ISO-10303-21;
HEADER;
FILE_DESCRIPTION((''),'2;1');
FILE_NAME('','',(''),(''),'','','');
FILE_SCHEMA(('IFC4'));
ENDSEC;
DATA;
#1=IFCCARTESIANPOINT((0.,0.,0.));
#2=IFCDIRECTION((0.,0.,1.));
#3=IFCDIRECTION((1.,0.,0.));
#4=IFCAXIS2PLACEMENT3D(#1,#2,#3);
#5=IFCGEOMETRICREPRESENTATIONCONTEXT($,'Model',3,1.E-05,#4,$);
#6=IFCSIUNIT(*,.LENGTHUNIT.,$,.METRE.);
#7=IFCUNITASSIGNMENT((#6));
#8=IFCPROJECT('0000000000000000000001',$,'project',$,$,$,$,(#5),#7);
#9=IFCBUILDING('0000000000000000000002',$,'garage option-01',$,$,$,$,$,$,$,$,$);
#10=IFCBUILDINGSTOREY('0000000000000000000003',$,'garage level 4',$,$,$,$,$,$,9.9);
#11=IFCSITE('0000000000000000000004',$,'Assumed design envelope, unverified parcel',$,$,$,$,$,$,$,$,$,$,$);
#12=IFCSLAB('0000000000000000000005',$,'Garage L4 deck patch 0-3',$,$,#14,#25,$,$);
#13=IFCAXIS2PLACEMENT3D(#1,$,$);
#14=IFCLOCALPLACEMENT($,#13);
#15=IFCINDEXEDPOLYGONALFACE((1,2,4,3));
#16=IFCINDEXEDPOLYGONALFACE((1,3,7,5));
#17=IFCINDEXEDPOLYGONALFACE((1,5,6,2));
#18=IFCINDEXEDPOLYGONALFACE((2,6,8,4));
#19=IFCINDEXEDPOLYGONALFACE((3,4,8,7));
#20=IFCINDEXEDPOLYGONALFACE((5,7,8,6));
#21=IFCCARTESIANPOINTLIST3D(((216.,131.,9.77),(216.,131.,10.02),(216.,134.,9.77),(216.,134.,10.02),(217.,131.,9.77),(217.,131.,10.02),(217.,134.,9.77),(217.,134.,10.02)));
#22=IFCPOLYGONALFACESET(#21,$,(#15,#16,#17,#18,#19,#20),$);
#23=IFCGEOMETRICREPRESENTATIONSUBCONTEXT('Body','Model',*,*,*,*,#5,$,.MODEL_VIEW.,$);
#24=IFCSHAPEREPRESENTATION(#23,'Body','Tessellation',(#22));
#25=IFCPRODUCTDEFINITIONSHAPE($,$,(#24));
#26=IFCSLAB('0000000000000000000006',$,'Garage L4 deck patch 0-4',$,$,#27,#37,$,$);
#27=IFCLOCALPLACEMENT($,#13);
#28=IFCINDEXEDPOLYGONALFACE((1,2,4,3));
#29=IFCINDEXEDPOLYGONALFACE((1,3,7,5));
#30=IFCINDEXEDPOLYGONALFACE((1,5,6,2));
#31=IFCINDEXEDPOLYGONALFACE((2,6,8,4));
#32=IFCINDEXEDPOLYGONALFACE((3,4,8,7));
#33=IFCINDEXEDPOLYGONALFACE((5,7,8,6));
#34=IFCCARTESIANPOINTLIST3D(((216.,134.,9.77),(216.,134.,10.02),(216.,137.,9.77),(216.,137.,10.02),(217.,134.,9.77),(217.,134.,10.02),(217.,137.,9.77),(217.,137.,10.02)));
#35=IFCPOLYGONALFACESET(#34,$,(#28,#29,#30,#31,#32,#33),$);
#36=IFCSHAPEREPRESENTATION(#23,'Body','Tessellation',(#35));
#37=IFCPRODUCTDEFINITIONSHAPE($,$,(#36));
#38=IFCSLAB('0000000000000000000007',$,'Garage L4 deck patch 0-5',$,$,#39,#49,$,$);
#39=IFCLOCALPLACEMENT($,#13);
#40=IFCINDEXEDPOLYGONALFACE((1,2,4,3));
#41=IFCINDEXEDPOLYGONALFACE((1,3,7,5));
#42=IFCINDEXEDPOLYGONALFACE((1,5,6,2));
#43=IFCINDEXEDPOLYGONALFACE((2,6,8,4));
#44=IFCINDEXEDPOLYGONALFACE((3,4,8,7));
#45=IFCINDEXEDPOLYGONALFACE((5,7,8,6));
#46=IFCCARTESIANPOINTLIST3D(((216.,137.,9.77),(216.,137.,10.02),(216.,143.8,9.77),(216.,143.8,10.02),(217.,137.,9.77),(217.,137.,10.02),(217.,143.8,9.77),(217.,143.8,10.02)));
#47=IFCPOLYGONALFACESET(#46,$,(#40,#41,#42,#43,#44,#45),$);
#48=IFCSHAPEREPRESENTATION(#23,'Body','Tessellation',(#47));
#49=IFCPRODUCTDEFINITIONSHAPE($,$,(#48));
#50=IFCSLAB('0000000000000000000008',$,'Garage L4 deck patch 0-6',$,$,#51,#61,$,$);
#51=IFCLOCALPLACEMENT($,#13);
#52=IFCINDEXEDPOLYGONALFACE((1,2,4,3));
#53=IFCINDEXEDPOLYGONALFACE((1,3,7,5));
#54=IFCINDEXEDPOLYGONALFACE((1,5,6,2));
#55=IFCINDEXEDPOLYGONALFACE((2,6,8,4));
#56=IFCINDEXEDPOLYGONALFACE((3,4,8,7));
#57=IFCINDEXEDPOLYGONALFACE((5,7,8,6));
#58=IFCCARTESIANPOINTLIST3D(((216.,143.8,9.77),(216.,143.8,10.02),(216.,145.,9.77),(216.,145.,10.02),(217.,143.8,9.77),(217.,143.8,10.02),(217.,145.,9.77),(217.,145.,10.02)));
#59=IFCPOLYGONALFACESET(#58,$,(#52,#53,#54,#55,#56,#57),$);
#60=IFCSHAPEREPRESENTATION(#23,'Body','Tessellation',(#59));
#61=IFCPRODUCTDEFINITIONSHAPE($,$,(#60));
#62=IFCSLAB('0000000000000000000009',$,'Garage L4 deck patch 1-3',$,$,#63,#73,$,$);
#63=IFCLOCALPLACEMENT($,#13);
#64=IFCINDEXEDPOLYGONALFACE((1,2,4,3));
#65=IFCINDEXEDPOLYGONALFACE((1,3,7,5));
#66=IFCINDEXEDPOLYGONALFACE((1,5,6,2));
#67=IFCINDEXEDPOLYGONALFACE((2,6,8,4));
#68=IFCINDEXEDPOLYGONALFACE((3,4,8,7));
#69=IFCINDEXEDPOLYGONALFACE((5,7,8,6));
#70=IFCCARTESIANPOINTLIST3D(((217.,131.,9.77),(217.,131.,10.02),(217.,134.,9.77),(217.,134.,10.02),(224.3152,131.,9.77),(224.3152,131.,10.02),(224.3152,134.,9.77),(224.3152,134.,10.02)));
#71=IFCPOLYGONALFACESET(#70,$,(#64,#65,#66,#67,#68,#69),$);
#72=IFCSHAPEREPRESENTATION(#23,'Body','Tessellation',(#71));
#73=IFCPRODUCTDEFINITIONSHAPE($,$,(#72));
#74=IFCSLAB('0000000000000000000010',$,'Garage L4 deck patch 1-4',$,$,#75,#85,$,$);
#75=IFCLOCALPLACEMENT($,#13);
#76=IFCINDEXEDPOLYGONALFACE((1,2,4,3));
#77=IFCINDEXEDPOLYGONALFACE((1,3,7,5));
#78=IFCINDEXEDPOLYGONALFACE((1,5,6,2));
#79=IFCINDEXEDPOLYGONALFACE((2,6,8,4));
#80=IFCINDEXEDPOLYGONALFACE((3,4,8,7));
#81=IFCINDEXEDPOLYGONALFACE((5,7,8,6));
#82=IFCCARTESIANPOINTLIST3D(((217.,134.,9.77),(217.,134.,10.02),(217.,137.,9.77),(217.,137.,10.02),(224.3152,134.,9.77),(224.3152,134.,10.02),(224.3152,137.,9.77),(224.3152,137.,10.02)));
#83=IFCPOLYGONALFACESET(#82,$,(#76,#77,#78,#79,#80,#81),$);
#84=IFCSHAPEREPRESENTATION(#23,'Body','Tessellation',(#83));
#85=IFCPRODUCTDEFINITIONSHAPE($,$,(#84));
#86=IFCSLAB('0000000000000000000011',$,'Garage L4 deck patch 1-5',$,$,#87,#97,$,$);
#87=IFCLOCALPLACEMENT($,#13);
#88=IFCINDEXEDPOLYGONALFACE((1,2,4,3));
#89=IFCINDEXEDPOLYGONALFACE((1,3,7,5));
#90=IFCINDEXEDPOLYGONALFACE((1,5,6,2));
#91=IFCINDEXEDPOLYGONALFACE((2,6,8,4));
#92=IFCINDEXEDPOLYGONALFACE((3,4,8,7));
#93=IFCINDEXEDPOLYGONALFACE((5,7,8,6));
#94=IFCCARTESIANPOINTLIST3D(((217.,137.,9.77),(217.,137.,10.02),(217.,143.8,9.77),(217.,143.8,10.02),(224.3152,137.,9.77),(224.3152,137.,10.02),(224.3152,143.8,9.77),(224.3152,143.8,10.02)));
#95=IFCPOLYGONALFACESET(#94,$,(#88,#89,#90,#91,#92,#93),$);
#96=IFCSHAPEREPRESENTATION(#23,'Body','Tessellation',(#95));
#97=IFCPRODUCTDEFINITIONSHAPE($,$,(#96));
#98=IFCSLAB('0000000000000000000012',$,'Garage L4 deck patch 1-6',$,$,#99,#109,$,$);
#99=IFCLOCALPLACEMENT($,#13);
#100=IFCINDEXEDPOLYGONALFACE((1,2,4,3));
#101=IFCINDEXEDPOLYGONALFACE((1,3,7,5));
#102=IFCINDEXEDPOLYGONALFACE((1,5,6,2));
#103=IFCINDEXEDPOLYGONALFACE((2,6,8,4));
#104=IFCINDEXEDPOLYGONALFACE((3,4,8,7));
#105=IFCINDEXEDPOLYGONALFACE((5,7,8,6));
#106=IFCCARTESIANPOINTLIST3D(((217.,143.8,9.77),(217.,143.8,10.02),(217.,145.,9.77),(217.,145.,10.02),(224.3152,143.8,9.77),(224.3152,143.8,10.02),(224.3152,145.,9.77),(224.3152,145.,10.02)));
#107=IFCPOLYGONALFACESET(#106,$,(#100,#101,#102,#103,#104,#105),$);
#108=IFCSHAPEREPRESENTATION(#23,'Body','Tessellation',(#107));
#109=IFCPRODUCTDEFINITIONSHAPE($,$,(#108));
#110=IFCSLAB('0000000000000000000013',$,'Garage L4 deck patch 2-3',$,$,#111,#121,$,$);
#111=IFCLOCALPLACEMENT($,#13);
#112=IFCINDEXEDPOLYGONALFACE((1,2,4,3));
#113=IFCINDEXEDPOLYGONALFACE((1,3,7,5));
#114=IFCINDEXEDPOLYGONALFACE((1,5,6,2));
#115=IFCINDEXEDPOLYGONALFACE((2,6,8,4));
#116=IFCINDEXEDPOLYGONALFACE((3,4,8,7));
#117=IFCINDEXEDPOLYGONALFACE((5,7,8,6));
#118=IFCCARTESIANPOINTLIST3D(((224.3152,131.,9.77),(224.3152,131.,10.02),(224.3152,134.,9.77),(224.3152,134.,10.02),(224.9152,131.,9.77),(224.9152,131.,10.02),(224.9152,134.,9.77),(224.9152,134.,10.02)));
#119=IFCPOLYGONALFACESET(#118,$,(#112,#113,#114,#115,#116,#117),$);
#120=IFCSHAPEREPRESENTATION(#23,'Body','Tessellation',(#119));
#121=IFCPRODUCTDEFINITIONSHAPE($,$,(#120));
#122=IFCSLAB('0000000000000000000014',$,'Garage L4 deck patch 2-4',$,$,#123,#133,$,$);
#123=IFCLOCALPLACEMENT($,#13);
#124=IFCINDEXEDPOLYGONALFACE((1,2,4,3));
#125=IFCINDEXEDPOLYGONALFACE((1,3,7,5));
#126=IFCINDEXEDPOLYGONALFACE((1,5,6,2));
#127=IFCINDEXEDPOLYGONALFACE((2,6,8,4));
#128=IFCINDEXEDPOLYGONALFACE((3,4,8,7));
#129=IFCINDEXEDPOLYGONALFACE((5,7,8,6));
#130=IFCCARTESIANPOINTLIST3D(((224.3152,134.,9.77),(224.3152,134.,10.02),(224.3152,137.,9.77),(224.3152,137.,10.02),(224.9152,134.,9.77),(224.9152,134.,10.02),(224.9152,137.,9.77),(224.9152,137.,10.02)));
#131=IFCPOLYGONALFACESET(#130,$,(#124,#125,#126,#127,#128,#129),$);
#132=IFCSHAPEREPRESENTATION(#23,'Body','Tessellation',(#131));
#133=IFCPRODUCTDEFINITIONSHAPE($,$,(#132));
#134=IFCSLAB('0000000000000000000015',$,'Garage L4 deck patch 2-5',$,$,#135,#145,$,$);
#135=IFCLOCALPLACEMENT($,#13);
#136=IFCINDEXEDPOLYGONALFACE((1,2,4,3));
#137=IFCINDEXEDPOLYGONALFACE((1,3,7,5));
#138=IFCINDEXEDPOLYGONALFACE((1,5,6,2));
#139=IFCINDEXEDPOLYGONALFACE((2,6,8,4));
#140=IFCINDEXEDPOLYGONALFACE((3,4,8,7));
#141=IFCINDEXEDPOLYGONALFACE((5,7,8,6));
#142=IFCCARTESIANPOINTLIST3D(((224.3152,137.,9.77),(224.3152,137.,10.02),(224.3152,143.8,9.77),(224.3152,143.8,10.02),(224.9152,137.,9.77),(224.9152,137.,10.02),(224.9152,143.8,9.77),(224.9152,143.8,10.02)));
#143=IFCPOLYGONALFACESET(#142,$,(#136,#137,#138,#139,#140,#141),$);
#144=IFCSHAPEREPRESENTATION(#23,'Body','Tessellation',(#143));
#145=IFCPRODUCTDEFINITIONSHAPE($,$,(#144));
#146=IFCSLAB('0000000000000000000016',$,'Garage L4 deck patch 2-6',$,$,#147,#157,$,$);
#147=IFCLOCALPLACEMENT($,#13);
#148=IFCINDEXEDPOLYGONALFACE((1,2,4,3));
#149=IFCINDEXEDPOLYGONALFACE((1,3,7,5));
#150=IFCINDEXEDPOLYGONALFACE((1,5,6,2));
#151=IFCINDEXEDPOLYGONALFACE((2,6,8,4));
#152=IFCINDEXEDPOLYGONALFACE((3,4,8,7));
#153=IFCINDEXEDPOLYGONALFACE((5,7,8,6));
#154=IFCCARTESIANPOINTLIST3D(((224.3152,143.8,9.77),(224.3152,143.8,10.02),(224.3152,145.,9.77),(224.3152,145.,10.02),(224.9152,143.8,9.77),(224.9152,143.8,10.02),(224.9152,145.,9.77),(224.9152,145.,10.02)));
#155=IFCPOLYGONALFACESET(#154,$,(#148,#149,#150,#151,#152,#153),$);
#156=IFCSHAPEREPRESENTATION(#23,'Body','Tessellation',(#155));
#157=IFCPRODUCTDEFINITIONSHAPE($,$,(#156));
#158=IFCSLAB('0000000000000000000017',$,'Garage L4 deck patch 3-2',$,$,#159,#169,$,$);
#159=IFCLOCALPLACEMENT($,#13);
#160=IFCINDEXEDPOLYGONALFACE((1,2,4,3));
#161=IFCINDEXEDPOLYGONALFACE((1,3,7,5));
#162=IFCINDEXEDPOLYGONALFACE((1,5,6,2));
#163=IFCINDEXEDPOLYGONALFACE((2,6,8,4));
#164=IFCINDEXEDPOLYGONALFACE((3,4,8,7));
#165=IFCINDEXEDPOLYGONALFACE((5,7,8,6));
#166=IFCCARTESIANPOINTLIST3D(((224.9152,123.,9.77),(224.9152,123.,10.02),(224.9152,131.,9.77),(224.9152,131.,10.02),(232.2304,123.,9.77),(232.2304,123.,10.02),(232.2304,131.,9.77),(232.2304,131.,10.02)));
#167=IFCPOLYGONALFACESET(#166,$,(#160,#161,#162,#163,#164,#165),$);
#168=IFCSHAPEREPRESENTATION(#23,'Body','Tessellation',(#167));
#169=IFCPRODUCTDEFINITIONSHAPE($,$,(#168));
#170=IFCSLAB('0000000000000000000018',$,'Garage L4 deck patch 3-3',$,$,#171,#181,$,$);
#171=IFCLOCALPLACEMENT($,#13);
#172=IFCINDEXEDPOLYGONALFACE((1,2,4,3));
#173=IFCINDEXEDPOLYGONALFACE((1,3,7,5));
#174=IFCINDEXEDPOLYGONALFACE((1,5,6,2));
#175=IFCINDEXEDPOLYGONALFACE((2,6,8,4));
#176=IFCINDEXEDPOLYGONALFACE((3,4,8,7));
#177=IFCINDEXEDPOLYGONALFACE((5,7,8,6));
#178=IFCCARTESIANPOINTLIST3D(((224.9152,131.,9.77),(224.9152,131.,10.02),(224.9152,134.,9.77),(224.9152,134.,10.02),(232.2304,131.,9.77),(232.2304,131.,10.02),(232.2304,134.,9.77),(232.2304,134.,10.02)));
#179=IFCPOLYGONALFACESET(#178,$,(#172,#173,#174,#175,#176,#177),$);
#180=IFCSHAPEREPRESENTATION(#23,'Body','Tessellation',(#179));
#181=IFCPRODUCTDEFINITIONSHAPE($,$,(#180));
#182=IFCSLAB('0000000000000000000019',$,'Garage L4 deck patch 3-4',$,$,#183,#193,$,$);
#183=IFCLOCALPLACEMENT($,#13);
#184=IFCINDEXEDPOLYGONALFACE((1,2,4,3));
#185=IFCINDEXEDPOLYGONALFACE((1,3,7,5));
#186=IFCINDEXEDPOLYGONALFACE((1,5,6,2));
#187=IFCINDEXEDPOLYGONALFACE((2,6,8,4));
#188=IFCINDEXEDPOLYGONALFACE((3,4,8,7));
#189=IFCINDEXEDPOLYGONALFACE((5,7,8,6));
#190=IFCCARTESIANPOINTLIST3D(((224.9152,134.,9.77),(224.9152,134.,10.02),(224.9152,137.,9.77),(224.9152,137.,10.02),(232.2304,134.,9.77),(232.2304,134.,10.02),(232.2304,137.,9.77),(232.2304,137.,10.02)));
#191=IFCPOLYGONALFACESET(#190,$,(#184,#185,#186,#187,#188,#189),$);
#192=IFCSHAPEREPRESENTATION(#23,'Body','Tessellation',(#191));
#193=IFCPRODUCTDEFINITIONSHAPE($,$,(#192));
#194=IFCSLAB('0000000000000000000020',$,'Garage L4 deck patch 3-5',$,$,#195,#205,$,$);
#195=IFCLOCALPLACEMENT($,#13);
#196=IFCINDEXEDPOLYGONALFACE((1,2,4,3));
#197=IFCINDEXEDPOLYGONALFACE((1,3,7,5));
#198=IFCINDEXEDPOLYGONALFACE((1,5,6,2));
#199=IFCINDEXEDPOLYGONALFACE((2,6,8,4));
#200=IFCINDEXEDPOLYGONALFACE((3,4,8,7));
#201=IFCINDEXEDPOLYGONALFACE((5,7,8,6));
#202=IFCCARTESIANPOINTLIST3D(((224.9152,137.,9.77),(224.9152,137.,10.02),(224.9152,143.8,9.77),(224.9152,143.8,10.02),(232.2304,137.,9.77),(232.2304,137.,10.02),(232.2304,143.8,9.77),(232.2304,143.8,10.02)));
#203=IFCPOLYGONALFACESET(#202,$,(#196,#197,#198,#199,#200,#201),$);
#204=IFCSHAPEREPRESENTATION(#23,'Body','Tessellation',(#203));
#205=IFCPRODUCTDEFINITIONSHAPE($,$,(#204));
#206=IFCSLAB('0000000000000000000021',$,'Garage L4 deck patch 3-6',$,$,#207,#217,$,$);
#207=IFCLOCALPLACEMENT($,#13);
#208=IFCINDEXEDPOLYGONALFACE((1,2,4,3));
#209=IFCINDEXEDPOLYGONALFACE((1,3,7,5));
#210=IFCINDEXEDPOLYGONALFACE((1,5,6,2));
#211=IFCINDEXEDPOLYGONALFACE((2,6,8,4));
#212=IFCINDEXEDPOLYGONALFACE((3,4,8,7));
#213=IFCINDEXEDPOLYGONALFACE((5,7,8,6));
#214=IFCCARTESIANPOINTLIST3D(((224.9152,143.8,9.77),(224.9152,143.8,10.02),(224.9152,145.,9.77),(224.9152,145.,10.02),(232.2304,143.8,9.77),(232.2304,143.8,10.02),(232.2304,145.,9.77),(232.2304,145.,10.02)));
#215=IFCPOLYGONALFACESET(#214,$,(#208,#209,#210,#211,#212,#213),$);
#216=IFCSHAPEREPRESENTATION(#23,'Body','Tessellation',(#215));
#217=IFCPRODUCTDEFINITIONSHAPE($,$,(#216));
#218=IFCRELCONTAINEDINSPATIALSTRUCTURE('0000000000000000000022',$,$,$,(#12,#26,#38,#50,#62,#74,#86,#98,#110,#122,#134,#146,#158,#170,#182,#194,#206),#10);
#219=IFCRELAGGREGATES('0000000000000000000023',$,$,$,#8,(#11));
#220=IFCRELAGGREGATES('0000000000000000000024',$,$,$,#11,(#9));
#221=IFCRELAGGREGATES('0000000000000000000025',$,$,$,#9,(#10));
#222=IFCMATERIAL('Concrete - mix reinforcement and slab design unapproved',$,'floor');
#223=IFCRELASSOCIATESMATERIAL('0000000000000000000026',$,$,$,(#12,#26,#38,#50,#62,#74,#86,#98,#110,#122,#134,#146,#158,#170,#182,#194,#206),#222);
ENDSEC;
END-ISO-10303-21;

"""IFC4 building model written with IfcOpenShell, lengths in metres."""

from ifc_helpers import new_model, si_unit, frame, origin_with_axes, place, context, subcontext, project, spatial, rectangle, extrude, material, element, save


model = new_model("IFC4")

# Units and contexts
model_context = context("Model", 3, precision=1e-05, world=origin_with_axes())
body_context = subcontext(model_context, "Body", "Model", "MODEL_VIEW")
ifc_project = project(units=[si_unit("LENGTHUNIT", "METRE")], contexts=[model_context])

# Site, building, storey
site = spatial("IfcSite", under=ifc_project, Name="Assumed design envelope, unverified parcel")
building = spatial("IfcBuilding", under=site, Name="garage option-01")
storey = spatial("IfcBuildingStorey", under=building, Name="garage level 4", Elevation=9.9)

# Slabs
ifc_material_1 = material(Name="Concrete - mix reinforcement and slab design unapproved", Category="floor")
for number, where, z_axis, x_axis, name in (
    (1, (216.5, 132.5, 9.77), (0.0, 0.0, 1.0), (1.0, 0.0, 0.0), "Garage L4 deck patch 0-3"),
    (2, (216.5, 135.5, 9.77), (0.0, 0.0, 1.0), (1.0, 0.0, 0.0), "Garage L4 deck patch 0-4"),
):
    element("IfcSlab", number, at=place(None, frame(where, z_axis=z_axis, x_axis=x_axis)), inside=storey, material=ifc_material_1, Name=name, context=body_context, shape_type="SweptSolid", body=[
        extrude(rectangle(XDim=1.0, YDim=3.0), origin_with_axes(), (0.0, 0.0, 1.0), 0.25),
    ])
slab_1_placement = place(None, frame((216.5, 140.4, 9.77), z_axis=(0.0, 0.0, 1.0), x_axis=(1.0, 0.0, 0.0)))
element("IfcSlab", 3, at=slab_1_placement, inside=storey, material=ifc_material_1, Name="Garage L4 deck patch 0-5", context=body_context, shape_type="SweptSolid", body=[
    extrude(rectangle(XDim=1.0, YDim=6.8), origin_with_axes(), (0.0, 0.0, 1.0), 0.25),
])
slab_2_placement = place(None, frame((216.5, 144.4, 9.77), z_axis=(0.0, 0.0, 1.0), x_axis=(1.0, 0.0, 0.0)))
element("IfcSlab", 4, at=slab_2_placement, inside=storey, material=ifc_material_1, Name="Garage L4 deck patch 0-6", context=body_context, shape_type="SweptSolid", body=[
    extrude(rectangle(XDim=1.0, YDim=1.2), origin_with_axes(), (0.0, 0.0, 1.0), 0.25),
])
for number, where, z_axis, x_axis, name in (
    (5, (220.6576, 132.5, 9.77), (0.0, 0.0, 1.0), (1.0, 0.0, 0.0), "Garage L4 deck patch 1-3"),
    (6, (220.6576, 135.5, 9.77), (0.0, 0.0, 1.0), (1.0, 0.0, 0.0), "Garage L4 deck patch 1-4"),
):
    element("IfcSlab", number, at=place(None, frame(where, z_axis=z_axis, x_axis=x_axis)), inside=storey, material=ifc_material_1, Name=name, context=body_context, shape_type="SweptSolid", body=[
        extrude(rectangle(XDim=7.3152, YDim=3.0), origin_with_axes(), (0.0, 0.0, 1.0), 0.25),
    ])
slab_3_placement = place(None, frame((220.6576, 140.4, 9.77), z_axis=(0.0, 0.0, 1.0), x_axis=(1.0, 0.0, 0.0)))
element("IfcSlab", 7, at=slab_3_placement, inside=storey, material=ifc_material_1, Name="Garage L4 deck patch 1-5", context=body_context, shape_type="SweptSolid", body=[
    extrude(rectangle(XDim=7.3152, YDim=6.8), origin_with_axes(), (0.0, 0.0, 1.0), 0.25),
])
slab_4_placement = place(None, frame((220.6576, 144.4, 9.77), z_axis=(0.0, 0.0, 1.0), x_axis=(1.0, 0.0, 0.0)))
element("IfcSlab", 8, at=slab_4_placement, inside=storey, material=ifc_material_1, Name="Garage L4 deck patch 1-6", context=body_context, shape_type="SweptSolid", body=[
    extrude(rectangle(XDim=7.3152, YDim=1.2), origin_with_axes(), (0.0, 0.0, 1.0), 0.25),
])
for number, where, z_axis, x_axis, name in (
    (9, (224.6152, 132.5, 9.77), (0.0, 0.0, 1.0), (1.0, 0.0, 0.0), "Garage L4 deck patch 2-3"),
    (10, (224.6152, 135.5, 9.77), (0.0, 0.0, 1.0), (1.0, 0.0, 0.0), "Garage L4 deck patch 2-4"),
):
    element("IfcSlab", number, at=place(None, frame(where, z_axis=z_axis, x_axis=x_axis)), inside=storey, material=ifc_material_1, Name=name, context=body_context, shape_type="SweptSolid", body=[
        extrude(rectangle(XDim=0.6, YDim=3.0), origin_with_axes(), (0.0, 0.0, 1.0), 0.25),
    ])
slab_5_placement = place(None, frame((224.6152, 140.4, 9.77), z_axis=(0.0, 0.0, 1.0), x_axis=(1.0, 0.0, 0.0)))
element("IfcSlab", 11, at=slab_5_placement, inside=storey, material=ifc_material_1, Name="Garage L4 deck patch 2-5", context=body_context, shape_type="SweptSolid", body=[
    extrude(rectangle(XDim=0.6, YDim=6.8), origin_with_axes(), (0.0, 0.0, 1.0), 0.25),
])
slab_6_placement = place(None, frame((224.6152, 144.4, 9.77), z_axis=(0.0, 0.0, 1.0), x_axis=(1.0, 0.0, 0.0)))
element("IfcSlab", 12, at=slab_6_placement, inside=storey, material=ifc_material_1, Name="Garage L4 deck patch 2-6", context=body_context, shape_type="SweptSolid", body=[
    extrude(rectangle(XDim=0.6, YDim=1.2), origin_with_axes(), (0.0, 0.0, 1.0), 0.25),
])
slab_7_placement = place(None, frame((228.5728, 127.0, 9.77), z_axis=(0.0, 0.0, 1.0), x_axis=(1.0, 0.0, 0.0)))
element("IfcSlab", 13, at=slab_7_placement, inside=storey, material=ifc_material_1, Name="Garage L4 deck patch 3-2", context=body_context, shape_type="SweptSolid", body=[
    extrude(rectangle(XDim=7.3152, YDim=8.0), origin_with_axes(), (0.0, 0.0, 1.0), 0.25),
])
for number, where, z_axis, x_axis, name in (
    (14, (228.5728, 132.5, 9.77), (0.0, 0.0, 1.0), (1.0, 0.0, 0.0), "Garage L4 deck patch 3-3"),
    (15, (228.5728, 135.5, 9.77), (0.0, 0.0, 1.0), (1.0, 0.0, 0.0), "Garage L4 deck patch 3-4"),
):
    element("IfcSlab", number, at=place(None, frame(where, z_axis=z_axis, x_axis=x_axis)), inside=storey, material=ifc_material_1, Name=name, context=body_context, shape_type="SweptSolid", body=[
        extrude(rectangle(XDim=7.3152, YDim=3.0), origin_with_axes(), (0.0, 0.0, 1.0), 0.25),
    ])
slab_8_placement = place(None, frame((228.5728, 140.4, 9.77), z_axis=(0.0, 0.0, 1.0), x_axis=(1.0, 0.0, 0.0)))
element("IfcSlab", 16, at=slab_8_placement, inside=storey, material=ifc_material_1, Name="Garage L4 deck patch 3-5", context=body_context, shape_type="SweptSolid", body=[
    extrude(rectangle(XDim=7.3152, YDim=6.8), origin_with_axes(), (0.0, 0.0, 1.0), 0.25),
])
slab_9_placement = place(None, frame((228.5728, 144.4, 9.77), z_axis=(0.0, 0.0, 1.0), x_axis=(1.0, 0.0, 0.0)))
element("IfcSlab", 17, at=slab_9_placement, inside=storey, material=ifc_material_1, Name="Garage L4 deck patch 3-6", context=body_context, shape_type="SweptSolid", body=[
    extrude(rectangle(XDim=7.3152, YDim=1.2), origin_with_axes(), (0.0, 0.0, 1.0), 0.25),
])

save(model, "model.ifc")
